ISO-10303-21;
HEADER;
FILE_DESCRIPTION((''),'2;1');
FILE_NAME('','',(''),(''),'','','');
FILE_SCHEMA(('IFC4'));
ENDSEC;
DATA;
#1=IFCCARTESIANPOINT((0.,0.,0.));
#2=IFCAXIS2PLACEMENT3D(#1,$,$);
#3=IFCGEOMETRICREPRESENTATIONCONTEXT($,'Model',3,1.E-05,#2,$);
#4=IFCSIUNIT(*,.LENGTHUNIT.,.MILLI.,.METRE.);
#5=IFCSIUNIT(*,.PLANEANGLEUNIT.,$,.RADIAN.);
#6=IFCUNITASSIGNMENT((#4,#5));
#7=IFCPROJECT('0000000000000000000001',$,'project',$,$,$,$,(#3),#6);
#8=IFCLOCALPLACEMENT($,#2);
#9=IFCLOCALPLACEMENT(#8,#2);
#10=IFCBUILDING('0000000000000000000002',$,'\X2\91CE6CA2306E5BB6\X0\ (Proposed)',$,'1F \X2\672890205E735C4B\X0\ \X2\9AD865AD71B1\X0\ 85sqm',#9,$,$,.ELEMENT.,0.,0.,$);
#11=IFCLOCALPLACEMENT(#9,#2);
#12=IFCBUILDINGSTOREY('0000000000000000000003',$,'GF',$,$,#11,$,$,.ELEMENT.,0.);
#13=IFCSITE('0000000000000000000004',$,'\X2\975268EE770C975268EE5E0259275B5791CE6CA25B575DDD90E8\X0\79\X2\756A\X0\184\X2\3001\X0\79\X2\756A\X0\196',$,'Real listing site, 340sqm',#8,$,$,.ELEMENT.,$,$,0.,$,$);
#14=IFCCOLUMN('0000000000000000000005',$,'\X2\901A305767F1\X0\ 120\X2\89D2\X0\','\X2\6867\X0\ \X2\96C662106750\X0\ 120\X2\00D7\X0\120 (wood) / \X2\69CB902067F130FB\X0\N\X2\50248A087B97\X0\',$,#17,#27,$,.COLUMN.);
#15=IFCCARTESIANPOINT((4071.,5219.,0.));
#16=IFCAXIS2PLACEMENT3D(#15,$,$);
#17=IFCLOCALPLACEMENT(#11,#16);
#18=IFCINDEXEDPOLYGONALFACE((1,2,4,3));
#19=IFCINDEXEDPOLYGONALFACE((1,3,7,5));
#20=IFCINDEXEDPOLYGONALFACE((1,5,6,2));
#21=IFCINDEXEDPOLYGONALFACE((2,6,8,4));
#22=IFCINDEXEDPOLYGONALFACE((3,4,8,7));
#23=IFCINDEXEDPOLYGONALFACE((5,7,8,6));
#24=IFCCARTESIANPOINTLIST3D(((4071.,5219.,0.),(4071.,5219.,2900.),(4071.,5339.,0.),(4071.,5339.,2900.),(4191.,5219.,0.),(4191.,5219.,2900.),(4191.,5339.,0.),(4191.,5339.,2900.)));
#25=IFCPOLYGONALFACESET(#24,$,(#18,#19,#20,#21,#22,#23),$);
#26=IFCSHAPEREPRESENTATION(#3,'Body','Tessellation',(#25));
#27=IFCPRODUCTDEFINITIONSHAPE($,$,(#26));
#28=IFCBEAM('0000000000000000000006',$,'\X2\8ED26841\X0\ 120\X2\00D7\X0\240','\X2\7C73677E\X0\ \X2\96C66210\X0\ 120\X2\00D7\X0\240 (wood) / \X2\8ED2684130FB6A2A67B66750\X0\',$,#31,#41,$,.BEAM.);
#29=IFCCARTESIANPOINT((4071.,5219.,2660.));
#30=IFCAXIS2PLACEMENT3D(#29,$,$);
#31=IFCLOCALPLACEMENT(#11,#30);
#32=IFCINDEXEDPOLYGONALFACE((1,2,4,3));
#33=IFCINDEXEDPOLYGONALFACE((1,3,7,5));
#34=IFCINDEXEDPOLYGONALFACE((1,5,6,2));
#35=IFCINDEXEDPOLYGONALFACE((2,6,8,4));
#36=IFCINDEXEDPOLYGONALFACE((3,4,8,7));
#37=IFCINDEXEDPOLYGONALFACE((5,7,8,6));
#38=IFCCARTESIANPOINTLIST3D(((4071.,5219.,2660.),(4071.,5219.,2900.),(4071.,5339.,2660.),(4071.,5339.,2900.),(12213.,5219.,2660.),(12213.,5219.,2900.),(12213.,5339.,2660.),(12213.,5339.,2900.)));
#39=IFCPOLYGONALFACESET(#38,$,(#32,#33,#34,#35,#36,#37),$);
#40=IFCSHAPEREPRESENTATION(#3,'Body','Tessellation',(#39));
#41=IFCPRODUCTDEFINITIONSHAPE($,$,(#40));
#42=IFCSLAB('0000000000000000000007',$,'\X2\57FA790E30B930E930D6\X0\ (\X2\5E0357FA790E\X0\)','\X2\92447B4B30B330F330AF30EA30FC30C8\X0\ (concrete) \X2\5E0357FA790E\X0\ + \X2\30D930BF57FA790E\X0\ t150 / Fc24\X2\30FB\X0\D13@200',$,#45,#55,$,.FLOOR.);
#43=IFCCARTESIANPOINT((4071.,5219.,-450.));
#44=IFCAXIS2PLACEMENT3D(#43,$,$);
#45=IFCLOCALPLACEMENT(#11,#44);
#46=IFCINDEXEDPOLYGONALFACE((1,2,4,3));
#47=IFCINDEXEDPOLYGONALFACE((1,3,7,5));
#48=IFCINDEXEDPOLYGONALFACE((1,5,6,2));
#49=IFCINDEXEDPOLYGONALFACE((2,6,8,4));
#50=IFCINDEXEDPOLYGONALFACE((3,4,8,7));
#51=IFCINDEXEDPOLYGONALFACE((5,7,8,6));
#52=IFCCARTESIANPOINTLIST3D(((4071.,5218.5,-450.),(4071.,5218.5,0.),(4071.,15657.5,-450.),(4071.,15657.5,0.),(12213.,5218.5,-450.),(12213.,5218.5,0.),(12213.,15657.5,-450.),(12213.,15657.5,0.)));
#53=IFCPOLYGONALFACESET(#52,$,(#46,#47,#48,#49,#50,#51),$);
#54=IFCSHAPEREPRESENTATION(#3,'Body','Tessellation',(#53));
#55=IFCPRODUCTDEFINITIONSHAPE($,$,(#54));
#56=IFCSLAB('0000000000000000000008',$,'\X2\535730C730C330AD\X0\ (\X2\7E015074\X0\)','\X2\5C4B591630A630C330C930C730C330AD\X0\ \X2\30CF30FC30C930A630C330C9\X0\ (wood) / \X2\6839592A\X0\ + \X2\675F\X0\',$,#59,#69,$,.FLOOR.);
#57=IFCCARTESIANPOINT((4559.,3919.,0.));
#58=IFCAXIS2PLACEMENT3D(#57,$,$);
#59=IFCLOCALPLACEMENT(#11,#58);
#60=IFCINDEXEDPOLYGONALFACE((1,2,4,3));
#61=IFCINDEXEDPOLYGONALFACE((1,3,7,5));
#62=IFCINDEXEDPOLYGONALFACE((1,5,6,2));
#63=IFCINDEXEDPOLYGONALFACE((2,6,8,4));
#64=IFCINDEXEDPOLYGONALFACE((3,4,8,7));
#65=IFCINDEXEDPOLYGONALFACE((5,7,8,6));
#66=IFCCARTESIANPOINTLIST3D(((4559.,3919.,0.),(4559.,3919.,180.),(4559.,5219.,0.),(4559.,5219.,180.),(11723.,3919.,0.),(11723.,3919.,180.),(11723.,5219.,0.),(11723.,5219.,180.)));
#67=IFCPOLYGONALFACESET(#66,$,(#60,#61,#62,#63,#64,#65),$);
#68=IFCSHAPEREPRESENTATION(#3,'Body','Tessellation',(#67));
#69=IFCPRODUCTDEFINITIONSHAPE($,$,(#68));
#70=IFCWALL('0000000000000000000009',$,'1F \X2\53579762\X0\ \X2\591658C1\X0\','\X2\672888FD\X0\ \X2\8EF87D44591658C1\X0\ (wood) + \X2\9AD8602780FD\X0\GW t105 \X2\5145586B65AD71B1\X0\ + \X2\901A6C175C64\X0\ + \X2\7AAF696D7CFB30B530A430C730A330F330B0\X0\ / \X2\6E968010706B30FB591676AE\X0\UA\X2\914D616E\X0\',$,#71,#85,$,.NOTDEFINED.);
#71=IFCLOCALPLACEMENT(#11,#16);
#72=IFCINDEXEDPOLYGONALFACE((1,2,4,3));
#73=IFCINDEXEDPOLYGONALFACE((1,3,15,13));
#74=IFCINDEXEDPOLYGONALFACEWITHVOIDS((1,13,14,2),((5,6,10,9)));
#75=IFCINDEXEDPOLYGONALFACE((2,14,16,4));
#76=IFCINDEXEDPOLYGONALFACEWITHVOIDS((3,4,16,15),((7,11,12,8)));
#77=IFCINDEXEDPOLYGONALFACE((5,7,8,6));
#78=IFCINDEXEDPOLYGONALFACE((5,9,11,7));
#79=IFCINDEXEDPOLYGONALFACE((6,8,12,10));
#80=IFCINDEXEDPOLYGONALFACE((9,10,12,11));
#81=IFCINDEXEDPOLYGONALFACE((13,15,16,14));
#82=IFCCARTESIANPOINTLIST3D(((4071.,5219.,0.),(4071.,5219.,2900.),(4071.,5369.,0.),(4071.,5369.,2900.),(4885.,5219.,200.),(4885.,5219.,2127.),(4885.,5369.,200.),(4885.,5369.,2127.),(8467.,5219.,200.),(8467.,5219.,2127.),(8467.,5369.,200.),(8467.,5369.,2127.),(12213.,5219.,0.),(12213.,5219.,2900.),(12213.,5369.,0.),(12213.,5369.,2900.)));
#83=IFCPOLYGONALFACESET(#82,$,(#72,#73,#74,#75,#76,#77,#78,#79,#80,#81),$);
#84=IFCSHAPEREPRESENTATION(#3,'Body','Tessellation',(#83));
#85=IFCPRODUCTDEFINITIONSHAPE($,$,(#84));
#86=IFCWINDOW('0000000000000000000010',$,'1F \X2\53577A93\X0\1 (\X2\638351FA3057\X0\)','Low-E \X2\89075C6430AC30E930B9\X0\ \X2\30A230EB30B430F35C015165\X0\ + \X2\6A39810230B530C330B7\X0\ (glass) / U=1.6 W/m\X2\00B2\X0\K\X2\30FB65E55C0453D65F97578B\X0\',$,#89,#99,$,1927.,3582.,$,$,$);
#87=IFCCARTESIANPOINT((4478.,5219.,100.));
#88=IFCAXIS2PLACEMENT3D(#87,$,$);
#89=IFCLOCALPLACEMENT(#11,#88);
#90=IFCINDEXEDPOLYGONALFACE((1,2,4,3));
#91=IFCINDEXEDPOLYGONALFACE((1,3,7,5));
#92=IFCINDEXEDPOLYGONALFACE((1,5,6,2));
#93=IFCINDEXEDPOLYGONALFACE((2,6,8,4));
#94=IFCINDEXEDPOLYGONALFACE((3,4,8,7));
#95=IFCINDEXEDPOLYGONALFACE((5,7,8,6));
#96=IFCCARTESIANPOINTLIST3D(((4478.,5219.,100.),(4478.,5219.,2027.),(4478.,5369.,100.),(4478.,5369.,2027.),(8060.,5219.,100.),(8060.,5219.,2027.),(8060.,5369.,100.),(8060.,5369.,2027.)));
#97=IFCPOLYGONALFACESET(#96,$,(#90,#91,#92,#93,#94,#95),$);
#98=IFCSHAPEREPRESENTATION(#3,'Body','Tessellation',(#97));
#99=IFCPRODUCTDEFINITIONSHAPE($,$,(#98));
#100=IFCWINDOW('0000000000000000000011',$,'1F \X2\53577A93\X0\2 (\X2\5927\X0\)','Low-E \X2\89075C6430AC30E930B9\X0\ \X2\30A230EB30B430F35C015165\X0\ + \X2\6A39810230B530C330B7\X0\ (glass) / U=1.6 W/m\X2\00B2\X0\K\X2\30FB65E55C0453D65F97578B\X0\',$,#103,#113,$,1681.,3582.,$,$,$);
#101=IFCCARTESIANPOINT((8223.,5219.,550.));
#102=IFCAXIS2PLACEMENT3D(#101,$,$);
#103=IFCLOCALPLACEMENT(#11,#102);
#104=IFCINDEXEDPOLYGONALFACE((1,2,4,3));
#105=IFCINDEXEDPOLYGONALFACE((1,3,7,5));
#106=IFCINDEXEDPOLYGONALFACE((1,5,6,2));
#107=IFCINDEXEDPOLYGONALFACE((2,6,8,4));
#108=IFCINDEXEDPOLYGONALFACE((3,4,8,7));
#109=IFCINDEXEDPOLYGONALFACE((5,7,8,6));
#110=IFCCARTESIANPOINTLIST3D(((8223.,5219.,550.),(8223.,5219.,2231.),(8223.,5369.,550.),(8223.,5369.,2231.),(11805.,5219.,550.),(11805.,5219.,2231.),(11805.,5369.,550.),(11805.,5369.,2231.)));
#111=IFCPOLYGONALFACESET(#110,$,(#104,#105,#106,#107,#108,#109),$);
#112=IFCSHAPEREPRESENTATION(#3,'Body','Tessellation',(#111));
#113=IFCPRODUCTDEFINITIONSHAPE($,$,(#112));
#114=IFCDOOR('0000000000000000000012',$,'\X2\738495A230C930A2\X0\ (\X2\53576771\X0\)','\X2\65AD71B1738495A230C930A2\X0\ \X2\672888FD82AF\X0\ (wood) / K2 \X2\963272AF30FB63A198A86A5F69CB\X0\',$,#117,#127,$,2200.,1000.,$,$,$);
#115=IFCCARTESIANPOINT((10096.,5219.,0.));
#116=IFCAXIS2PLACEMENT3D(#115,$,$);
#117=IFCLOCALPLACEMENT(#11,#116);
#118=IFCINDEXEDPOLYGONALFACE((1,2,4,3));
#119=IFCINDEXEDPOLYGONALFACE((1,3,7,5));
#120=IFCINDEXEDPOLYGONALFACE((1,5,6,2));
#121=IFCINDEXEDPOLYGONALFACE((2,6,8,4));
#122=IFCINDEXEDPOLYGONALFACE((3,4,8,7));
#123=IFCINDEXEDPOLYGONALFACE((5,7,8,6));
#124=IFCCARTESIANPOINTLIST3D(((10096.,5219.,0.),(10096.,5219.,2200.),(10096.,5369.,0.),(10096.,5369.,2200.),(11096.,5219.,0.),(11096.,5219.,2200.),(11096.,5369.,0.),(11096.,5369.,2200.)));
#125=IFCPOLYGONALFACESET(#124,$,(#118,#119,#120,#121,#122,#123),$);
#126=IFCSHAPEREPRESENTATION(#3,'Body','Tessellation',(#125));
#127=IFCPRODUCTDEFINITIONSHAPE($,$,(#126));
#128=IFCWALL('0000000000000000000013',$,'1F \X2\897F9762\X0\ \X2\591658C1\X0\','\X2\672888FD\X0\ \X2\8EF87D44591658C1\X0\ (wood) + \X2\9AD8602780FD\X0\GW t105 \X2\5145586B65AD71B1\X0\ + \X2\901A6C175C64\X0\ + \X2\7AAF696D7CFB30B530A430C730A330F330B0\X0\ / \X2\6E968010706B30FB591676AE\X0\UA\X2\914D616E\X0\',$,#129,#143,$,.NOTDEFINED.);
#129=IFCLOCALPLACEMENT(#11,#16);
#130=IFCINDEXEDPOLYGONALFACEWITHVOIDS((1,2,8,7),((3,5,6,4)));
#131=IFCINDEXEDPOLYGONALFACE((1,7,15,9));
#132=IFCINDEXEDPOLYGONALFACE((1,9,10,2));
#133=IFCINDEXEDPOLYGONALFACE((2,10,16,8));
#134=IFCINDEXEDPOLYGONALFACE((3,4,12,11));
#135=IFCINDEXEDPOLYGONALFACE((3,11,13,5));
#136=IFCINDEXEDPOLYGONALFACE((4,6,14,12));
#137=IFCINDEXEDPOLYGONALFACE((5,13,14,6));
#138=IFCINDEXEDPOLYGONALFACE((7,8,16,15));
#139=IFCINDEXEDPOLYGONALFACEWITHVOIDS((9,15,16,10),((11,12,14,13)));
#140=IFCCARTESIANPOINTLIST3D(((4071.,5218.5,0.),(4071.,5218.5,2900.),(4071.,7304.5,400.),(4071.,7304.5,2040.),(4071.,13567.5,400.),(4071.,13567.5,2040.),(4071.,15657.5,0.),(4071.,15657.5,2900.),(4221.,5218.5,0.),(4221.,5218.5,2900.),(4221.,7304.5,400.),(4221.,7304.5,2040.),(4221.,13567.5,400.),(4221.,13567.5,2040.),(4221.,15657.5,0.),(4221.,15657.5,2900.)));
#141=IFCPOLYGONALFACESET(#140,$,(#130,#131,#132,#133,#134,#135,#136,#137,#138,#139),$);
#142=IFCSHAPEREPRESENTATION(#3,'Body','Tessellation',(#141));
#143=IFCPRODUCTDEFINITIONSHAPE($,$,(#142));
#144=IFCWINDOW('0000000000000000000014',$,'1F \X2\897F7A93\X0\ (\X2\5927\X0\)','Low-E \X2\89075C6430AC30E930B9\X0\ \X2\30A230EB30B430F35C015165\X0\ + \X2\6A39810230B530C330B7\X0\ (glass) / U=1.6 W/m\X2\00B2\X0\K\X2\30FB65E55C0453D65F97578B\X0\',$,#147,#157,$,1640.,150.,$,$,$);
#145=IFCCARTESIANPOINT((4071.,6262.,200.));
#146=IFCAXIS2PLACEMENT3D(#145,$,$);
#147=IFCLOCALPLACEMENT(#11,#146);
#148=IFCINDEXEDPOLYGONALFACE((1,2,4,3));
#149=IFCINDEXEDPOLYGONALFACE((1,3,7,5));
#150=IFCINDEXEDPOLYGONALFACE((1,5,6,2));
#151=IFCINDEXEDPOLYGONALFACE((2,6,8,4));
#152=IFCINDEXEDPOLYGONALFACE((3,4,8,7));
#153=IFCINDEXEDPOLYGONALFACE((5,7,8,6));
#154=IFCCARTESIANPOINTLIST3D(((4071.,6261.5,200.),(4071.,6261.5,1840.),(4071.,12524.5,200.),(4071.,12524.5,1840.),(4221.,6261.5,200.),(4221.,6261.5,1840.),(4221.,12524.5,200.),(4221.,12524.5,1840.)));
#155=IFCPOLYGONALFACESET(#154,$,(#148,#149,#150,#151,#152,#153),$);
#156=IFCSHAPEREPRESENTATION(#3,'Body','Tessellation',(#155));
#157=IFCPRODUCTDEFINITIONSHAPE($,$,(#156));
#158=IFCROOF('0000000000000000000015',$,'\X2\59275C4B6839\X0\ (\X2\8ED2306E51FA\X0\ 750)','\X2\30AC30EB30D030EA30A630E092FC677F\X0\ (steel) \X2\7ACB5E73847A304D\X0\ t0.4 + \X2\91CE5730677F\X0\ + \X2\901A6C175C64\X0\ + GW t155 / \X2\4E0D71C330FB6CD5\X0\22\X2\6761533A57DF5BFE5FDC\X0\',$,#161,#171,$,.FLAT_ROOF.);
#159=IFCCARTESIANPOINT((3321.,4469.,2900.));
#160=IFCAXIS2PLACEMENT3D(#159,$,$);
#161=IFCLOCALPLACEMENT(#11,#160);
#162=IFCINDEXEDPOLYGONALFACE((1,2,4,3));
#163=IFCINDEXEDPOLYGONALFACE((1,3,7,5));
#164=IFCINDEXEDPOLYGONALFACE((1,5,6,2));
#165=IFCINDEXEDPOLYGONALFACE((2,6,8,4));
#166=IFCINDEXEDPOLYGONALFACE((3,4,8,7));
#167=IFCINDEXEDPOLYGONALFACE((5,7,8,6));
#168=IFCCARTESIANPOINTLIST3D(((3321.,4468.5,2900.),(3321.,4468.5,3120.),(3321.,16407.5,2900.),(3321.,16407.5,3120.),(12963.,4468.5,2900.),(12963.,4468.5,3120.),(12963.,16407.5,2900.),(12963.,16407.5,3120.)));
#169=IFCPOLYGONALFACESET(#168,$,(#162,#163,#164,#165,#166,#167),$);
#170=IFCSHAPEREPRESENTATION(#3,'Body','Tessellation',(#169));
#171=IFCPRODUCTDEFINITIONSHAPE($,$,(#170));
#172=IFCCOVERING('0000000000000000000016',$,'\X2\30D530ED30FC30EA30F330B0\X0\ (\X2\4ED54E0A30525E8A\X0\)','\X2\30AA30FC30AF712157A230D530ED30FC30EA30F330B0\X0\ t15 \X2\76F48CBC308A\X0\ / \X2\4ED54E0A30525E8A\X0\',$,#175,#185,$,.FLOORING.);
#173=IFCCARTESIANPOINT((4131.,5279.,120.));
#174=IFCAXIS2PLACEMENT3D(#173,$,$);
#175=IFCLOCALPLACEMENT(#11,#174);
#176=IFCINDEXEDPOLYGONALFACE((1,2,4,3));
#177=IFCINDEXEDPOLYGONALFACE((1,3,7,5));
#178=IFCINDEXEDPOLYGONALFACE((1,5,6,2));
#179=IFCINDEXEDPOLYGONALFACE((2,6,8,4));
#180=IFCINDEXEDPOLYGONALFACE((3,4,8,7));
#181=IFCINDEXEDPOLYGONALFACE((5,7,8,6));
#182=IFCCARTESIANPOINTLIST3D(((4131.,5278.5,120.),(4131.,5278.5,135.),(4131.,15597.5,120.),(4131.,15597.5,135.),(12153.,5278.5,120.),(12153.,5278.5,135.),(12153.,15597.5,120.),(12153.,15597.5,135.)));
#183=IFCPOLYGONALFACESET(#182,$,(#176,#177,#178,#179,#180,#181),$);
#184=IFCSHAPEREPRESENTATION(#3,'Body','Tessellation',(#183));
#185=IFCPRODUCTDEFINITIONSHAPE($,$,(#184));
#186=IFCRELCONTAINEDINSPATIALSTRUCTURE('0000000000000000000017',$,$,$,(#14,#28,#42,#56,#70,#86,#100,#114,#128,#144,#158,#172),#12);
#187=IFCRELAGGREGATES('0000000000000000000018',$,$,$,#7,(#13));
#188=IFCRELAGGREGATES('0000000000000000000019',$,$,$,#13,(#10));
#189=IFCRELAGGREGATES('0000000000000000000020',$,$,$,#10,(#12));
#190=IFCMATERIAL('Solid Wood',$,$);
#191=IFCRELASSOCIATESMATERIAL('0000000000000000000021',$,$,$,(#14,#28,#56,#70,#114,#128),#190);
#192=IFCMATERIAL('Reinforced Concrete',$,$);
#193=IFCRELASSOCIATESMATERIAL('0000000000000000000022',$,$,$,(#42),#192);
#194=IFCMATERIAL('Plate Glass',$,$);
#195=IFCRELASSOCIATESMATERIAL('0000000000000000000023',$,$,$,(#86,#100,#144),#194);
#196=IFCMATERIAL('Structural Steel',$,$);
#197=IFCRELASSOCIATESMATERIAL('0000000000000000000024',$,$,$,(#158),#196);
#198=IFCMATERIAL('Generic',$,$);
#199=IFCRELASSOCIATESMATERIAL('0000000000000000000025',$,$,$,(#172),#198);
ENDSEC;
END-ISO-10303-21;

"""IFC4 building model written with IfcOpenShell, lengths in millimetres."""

from ifc_helpers import new_model, si_unit, frame, frame_2d, origin, place, context, project, spatial, rectangle, extrude, material, element, fill, save


model = new_model("IFC4")

# Units and contexts
model_context = context("Model", 3, precision=1e-05, world=origin())
ifc_project = project(units=[si_unit("LENGTHUNIT", "METRE", prefix="MILLI"), si_unit("PLANEANGLEUNIT", "RADIAN")], contexts=[model_context])

# Site, building, storey
site_placement = place(None, origin())
site = spatial("IfcSite", under=ifc_project, at=site_placement, Name="青森県青森市大字野沢字川部79番184、79番196", ObjectType="Real listing site, 340sqm", CompositionType="ELEMENT", RefElevation=0.0)
building_placement = place(site_placement, origin())
building = spatial("IfcBuilding", under=site, at=building_placement, Name="野沢の家 (Proposed)", ObjectType="1F 木造平屋 高断熱 85sqm", CompositionType="ELEMENT", ElevationOfRefHeight=0.0, ElevationOfTerrain=0.0)
storey_placement = place(building_placement, origin())
storey = spatial("IfcBuildingStorey", under=building, at=storey_placement, Name="GF", CompositionType="ELEMENT", Elevation=0.0)

# Column
ifc_material_1 = material(Name="Solid Wood")
column_1_placement = place(storey_placement, frame((4071.0, 5219.0, 0.0)))
element("IfcColumn", 1, at=column_1_placement, inside=storey, material=ifc_material_1, Name="通し柱 120角", Description="桧 集成材 120×120 (wood) / 構造柱・N値計算", PredefinedType="COLUMN", context=model_context, shape_type="SweptSolid", body=[
    extrude(rectangle(XDim=120.0, YDim=120.0, at=frame_2d((60.0, 60.0))), frame((4071.0, 5219.0, 0.0)), (0.0, 0.0, 1.0), 2900.0),
])

# Beam
beam_1_placement = place(storey_placement, frame((4071.0, 5219.0, 2660.0)))
element("IfcBeam", 2, at=beam_1_placement, inside=storey, material=ifc_material_1, Name="軒桁 120×240", Description="米松 集成 120×240 (wood) / 軒桁・横架材", PredefinedType="BEAM", context=model_context, shape_type="SweptSolid", body=[
    extrude(rectangle(XDim=8142.0, YDim=120.0, at=frame_2d((4071.0, 60.0))), frame((4071.0, 5219.0, 2660.0)), (0.0, 0.0, 1.0), 240.0),
])

# Slabs
ifc_material_2 = material(Name="Reinforced Concrete")
slab_1_placement = place(storey_placement, frame((4071.0, 5219.0, -450.0)))
element("IfcSlab", 3, at=slab_1_placement, inside=storey, material=ifc_material_2, Name="基礎スラブ (布基礎)", Description="鉄筋コンクリート (concrete) 布基礎 + ベタ基礎 t150 / Fc24・D13@200", PredefinedType="FLOOR", context=model_context, shape_type="SweptSolid", body=[
    extrude(rectangle(XDim=8142.0, YDim=10439.0, at=frame_2d((4071.0, 5219.0))), frame((4071.0, 5219.0, -450.0)), (0.0, 0.0, 1.0), 450.0),
])
slab_2_placement = place(storey_placement, frame((4559.0, 3919.0, 0.0)))
element("IfcSlab", 4, at=slab_2_placement, inside=storey, material=ifc_material_1, Name="南デッキ (縁側)", Description="屋外ウッドデッキ ハードウッド (wood) / 根太 + 束", PredefinedType="FLOOR", context=model_context, shape_type="SweptSolid", body=[
    extrude(rectangle(XDim=7164.0, YDim=1300.0, at=frame_2d((3582.0, 650.0))), frame((4559.0, 3919.0, 0.0)), (0.0, 0.0, 1.0), 180.0),
])

# Wall, openings, windows, door
wall_1_placement = place(storey_placement, frame((4071.0, 5219.0, 0.0)))
wall_1 = element("IfcWall", 5, at=wall_1_placement, inside=storey, material=ifc_material_1, Name="1F 南面 外壁", Description="木製 軸組外壁 (wood) + 高性能GW t105 充填断熱 + 通気層 + 窯業系サイディング / 準耐火・外皮UA配慮", PredefinedType="NOTDEFINED", context=model_context, shape_type="SweptSolid", body=[
    extrude(rectangle(XDim=8142.0, YDim=150.0, at=frame_2d((4071.0, 75.0))), frame((4071.0, 5219.0, 0.0)), (0.0, 0.0, 1.0), 2900.0),
])
opening_1_placement = place(storey_placement, frame((4478.0, 5219.0, 100.0)))
opening_1 = element("IfcOpeningElement", 6, at=opening_1_placement, cuts=wall_1, PredefinedType="NOTDEFINED", context=model_context, shape_type="SweptSolid", body=[
    extrude(rectangle(XDim=3582.0, YDim=150.0, at=frame_2d((1791.0, 75.0))), frame((4478.0, 5219.0, 100.0)), (0.0, 0.0, 1.0), 1927.0),
])
opening_2_placement = place(storey_placement, frame((8223.0, 5219.0, 550.0)))
opening_2 = element("IfcOpeningElement", 7, at=opening_2_placement, cuts=wall_1, PredefinedType="NOTDEFINED", context=model_context, shape_type="SweptSolid", body=[
    extrude(rectangle(XDim=3582.0, YDim=150.0, at=frame_2d((1791.0, 75.0))), frame((8223.0, 5219.0, 550.0)), (0.0, 0.0, 1.0), 1681.0),
])
opening_3_placement = place(storey_placement, frame((10096.0, 5219.0, 0.0)))
opening_3 = element("IfcOpeningElement", 8, at=opening_3_placement, cuts=wall_1, PredefinedType="NOTDEFINED", context=model_context, shape_type="SweptSolid", body=[
    extrude(rectangle(XDim=1000.0, YDim=150.0, at=frame_2d((500.0, 75.0))), frame((10096.0, 5219.0, 0.0)), (0.0, 0.0, 1.0), 2200.0),
])
ifc_material_3 = material(Name="Plate Glass")
window_1_placement = place(storey_placement, frame((4478.0, 5219.0, 100.0)))
window_1 = element("IfcWindow", 9, at=window_1_placement, inside=storey, material=ifc_material_3, Name="1F 南窓1 (掃出し)", Description="Low-E 複層ガラス アルゴン封入 + 樹脂サッシ (glass) / U=1.6 W/m²K・日射取得型", OverallHeight=1927.0, OverallWidth=3582.0, context=model_context, shape_type="SweptSolid", body=[
    extrude(rectangle(XDim=3582.0, YDim=150.0, at=frame_2d((1791.0, 75.0))), frame((4478.0, 5219.0, 100.0)), (0.0, 0.0, 1.0), 1927.0),
])
fill(opening_1, window_1)
window_2_placement = place(storey_placement, frame((8223.0, 5219.0, 550.0)))
window_2 = element("IfcWindow", 10, at=window_2_placement, inside=storey, material=ifc_material_3, Name="1F 南窓2 (大)", Description="Low-E 複層ガラス アルゴン封入 + 樹脂サッシ (glass) / U=1.6 W/m²K・日射取得型", OverallHeight=1681.0, OverallWidth=3582.0, context=model_context, shape_type="SweptSolid", body=[
    extrude(rectangle(XDim=3582.0, YDim=150.0, at=frame_2d((1791.0, 75.0))), frame((8223.0, 5219.0, 550.0)), (0.0, 0.0, 1.0), 1681.0),
])
fill(opening_2, window_2)
door_placement = place(storey_placement, frame((10096.0, 5219.0, 0.0)))
door = element("IfcDoor", 11, at=door_placement, inside=storey, material=ifc_material_1, Name="玄関ドア (南東)", Description="断熱玄関ドア 木製芯 (wood) / K2 防犯・採風機構", OverallHeight=2200.0, OverallWidth=1000.0, context=model_context, shape_type="SweptSolid", body=[
    extrude(rectangle(XDim=1000.0, YDim=150.0, at=frame_2d((500.0, 75.0))), frame((10096.0, 5219.0, 0.0)), (0.0, 0.0, 1.0), 2200.0),
])
fill(opening_3, door)

# Wall, opening, window
wall_2_placement = place(storey_placement, frame((4071.0, 5219.0, 0.0)))
wall_2 = element("IfcWall", 12, at=wall_2_placement, inside=storey, material=ifc_material_1, Name="1F 西面 外壁", Description="木製 軸組外壁 (wood) + 高性能GW t105 充填断熱 + 通気層 + 窯業系サイディング / 準耐火・外皮UA配慮", PredefinedType="NOTDEFINED", context=model_context, shape_type="SweptSolid", body=[
    extrude(rectangle(XDim=150.0, YDim=10439.0, at=frame_2d((75.0, 5219.0))), frame((4071.0, 5219.0, 0.0)), (0.0, 0.0, 1.0), 2900.0),
])
opening_4_placement = place(storey_placement, frame((4071.0, 6262.0, 200.0)))
opening_4 = element("IfcOpeningElement", 13, at=opening_4_placement, cuts=wall_2, PredefinedType="NOTDEFINED", context=model_context, shape_type="SweptSolid", body=[
    extrude(rectangle(XDim=150.0, YDim=6263.0, at=frame_2d((75.0, 3131.0))), frame((4071.0, 6262.0, 200.0)), (0.0, 0.0, 1.0), 1640.0),
])
window_3_placement = place(storey_placement, frame((4071.0, 6262.0, 200.0)))
window_3 = element("IfcWindow", 14, at=window_3_placement, inside=storey, material=ifc_material_3, Name="1F 西窓 (大)", Description="Low-E 複層ガラス アルゴン封入 + 樹脂サッシ (glass) / U=1.6 W/m²K・日射取得型", OverallHeight=1640.0, OverallWidth=150.0, context=model_context, shape_type="SweptSolid", body=[
    extrude(rectangle(XDim=150.0, YDim=6263.0, at=frame_2d((75.0, 3131.0))), frame((4071.0, 6262.0, 200.0)), (0.0, 0.0, 1.0), 1640.0),
])
fill(opening_4, window_3)

# Roof
ifc_material_4 = material(Name="Structural Steel")
roof_placement = place(storey_placement, frame((3321.0, 4469.0, 2900.0)))
element("IfcRoof", 15, at=roof_placement, inside=storey, material=ifc_material_4, Name="大屋根 (軒の出 750)", Description="ガルバリウム鋼板 (steel) 立平葺き t0.4 + 野地板 + 通気層 + GW t155 / 不燃・法22条区域対応", PredefinedType="FLAT_ROOF", context=model_context, shape_type="SweptSolid", body=[
    extrude(rectangle(XDim=9642.0, YDim=11939.0, at=frame_2d((4821.0, 5969.0))), frame((3321.0, 4469.0, 2900.0)), (0.0, 0.0, 1.0), 220.0),
])

# Covering
ifc_material_5 = material(Name="Generic")
covering_1_placement = place(storey_placement, frame((4131.0, 5279.0, 120.0)))
element("IfcCovering", 16, at=covering_1_placement, inside=storey, material=ifc_material_5, Name="フローリング (仕上げ床)", Description="オーク無垢フローリング t15 直貼り / 仕上げ床", PredefinedType="FLOORING", context=model_context, shape_type="SweptSolid", body=[
    extrude(rectangle(XDim=8022.0, YDim=10319.0, at=frame_2d((4011.0, 5159.0))), frame((4131.0, 5279.0, 120.0)), (0.0, 0.0, 1.0), 15.0),
])

save(model, "model.ifc")
